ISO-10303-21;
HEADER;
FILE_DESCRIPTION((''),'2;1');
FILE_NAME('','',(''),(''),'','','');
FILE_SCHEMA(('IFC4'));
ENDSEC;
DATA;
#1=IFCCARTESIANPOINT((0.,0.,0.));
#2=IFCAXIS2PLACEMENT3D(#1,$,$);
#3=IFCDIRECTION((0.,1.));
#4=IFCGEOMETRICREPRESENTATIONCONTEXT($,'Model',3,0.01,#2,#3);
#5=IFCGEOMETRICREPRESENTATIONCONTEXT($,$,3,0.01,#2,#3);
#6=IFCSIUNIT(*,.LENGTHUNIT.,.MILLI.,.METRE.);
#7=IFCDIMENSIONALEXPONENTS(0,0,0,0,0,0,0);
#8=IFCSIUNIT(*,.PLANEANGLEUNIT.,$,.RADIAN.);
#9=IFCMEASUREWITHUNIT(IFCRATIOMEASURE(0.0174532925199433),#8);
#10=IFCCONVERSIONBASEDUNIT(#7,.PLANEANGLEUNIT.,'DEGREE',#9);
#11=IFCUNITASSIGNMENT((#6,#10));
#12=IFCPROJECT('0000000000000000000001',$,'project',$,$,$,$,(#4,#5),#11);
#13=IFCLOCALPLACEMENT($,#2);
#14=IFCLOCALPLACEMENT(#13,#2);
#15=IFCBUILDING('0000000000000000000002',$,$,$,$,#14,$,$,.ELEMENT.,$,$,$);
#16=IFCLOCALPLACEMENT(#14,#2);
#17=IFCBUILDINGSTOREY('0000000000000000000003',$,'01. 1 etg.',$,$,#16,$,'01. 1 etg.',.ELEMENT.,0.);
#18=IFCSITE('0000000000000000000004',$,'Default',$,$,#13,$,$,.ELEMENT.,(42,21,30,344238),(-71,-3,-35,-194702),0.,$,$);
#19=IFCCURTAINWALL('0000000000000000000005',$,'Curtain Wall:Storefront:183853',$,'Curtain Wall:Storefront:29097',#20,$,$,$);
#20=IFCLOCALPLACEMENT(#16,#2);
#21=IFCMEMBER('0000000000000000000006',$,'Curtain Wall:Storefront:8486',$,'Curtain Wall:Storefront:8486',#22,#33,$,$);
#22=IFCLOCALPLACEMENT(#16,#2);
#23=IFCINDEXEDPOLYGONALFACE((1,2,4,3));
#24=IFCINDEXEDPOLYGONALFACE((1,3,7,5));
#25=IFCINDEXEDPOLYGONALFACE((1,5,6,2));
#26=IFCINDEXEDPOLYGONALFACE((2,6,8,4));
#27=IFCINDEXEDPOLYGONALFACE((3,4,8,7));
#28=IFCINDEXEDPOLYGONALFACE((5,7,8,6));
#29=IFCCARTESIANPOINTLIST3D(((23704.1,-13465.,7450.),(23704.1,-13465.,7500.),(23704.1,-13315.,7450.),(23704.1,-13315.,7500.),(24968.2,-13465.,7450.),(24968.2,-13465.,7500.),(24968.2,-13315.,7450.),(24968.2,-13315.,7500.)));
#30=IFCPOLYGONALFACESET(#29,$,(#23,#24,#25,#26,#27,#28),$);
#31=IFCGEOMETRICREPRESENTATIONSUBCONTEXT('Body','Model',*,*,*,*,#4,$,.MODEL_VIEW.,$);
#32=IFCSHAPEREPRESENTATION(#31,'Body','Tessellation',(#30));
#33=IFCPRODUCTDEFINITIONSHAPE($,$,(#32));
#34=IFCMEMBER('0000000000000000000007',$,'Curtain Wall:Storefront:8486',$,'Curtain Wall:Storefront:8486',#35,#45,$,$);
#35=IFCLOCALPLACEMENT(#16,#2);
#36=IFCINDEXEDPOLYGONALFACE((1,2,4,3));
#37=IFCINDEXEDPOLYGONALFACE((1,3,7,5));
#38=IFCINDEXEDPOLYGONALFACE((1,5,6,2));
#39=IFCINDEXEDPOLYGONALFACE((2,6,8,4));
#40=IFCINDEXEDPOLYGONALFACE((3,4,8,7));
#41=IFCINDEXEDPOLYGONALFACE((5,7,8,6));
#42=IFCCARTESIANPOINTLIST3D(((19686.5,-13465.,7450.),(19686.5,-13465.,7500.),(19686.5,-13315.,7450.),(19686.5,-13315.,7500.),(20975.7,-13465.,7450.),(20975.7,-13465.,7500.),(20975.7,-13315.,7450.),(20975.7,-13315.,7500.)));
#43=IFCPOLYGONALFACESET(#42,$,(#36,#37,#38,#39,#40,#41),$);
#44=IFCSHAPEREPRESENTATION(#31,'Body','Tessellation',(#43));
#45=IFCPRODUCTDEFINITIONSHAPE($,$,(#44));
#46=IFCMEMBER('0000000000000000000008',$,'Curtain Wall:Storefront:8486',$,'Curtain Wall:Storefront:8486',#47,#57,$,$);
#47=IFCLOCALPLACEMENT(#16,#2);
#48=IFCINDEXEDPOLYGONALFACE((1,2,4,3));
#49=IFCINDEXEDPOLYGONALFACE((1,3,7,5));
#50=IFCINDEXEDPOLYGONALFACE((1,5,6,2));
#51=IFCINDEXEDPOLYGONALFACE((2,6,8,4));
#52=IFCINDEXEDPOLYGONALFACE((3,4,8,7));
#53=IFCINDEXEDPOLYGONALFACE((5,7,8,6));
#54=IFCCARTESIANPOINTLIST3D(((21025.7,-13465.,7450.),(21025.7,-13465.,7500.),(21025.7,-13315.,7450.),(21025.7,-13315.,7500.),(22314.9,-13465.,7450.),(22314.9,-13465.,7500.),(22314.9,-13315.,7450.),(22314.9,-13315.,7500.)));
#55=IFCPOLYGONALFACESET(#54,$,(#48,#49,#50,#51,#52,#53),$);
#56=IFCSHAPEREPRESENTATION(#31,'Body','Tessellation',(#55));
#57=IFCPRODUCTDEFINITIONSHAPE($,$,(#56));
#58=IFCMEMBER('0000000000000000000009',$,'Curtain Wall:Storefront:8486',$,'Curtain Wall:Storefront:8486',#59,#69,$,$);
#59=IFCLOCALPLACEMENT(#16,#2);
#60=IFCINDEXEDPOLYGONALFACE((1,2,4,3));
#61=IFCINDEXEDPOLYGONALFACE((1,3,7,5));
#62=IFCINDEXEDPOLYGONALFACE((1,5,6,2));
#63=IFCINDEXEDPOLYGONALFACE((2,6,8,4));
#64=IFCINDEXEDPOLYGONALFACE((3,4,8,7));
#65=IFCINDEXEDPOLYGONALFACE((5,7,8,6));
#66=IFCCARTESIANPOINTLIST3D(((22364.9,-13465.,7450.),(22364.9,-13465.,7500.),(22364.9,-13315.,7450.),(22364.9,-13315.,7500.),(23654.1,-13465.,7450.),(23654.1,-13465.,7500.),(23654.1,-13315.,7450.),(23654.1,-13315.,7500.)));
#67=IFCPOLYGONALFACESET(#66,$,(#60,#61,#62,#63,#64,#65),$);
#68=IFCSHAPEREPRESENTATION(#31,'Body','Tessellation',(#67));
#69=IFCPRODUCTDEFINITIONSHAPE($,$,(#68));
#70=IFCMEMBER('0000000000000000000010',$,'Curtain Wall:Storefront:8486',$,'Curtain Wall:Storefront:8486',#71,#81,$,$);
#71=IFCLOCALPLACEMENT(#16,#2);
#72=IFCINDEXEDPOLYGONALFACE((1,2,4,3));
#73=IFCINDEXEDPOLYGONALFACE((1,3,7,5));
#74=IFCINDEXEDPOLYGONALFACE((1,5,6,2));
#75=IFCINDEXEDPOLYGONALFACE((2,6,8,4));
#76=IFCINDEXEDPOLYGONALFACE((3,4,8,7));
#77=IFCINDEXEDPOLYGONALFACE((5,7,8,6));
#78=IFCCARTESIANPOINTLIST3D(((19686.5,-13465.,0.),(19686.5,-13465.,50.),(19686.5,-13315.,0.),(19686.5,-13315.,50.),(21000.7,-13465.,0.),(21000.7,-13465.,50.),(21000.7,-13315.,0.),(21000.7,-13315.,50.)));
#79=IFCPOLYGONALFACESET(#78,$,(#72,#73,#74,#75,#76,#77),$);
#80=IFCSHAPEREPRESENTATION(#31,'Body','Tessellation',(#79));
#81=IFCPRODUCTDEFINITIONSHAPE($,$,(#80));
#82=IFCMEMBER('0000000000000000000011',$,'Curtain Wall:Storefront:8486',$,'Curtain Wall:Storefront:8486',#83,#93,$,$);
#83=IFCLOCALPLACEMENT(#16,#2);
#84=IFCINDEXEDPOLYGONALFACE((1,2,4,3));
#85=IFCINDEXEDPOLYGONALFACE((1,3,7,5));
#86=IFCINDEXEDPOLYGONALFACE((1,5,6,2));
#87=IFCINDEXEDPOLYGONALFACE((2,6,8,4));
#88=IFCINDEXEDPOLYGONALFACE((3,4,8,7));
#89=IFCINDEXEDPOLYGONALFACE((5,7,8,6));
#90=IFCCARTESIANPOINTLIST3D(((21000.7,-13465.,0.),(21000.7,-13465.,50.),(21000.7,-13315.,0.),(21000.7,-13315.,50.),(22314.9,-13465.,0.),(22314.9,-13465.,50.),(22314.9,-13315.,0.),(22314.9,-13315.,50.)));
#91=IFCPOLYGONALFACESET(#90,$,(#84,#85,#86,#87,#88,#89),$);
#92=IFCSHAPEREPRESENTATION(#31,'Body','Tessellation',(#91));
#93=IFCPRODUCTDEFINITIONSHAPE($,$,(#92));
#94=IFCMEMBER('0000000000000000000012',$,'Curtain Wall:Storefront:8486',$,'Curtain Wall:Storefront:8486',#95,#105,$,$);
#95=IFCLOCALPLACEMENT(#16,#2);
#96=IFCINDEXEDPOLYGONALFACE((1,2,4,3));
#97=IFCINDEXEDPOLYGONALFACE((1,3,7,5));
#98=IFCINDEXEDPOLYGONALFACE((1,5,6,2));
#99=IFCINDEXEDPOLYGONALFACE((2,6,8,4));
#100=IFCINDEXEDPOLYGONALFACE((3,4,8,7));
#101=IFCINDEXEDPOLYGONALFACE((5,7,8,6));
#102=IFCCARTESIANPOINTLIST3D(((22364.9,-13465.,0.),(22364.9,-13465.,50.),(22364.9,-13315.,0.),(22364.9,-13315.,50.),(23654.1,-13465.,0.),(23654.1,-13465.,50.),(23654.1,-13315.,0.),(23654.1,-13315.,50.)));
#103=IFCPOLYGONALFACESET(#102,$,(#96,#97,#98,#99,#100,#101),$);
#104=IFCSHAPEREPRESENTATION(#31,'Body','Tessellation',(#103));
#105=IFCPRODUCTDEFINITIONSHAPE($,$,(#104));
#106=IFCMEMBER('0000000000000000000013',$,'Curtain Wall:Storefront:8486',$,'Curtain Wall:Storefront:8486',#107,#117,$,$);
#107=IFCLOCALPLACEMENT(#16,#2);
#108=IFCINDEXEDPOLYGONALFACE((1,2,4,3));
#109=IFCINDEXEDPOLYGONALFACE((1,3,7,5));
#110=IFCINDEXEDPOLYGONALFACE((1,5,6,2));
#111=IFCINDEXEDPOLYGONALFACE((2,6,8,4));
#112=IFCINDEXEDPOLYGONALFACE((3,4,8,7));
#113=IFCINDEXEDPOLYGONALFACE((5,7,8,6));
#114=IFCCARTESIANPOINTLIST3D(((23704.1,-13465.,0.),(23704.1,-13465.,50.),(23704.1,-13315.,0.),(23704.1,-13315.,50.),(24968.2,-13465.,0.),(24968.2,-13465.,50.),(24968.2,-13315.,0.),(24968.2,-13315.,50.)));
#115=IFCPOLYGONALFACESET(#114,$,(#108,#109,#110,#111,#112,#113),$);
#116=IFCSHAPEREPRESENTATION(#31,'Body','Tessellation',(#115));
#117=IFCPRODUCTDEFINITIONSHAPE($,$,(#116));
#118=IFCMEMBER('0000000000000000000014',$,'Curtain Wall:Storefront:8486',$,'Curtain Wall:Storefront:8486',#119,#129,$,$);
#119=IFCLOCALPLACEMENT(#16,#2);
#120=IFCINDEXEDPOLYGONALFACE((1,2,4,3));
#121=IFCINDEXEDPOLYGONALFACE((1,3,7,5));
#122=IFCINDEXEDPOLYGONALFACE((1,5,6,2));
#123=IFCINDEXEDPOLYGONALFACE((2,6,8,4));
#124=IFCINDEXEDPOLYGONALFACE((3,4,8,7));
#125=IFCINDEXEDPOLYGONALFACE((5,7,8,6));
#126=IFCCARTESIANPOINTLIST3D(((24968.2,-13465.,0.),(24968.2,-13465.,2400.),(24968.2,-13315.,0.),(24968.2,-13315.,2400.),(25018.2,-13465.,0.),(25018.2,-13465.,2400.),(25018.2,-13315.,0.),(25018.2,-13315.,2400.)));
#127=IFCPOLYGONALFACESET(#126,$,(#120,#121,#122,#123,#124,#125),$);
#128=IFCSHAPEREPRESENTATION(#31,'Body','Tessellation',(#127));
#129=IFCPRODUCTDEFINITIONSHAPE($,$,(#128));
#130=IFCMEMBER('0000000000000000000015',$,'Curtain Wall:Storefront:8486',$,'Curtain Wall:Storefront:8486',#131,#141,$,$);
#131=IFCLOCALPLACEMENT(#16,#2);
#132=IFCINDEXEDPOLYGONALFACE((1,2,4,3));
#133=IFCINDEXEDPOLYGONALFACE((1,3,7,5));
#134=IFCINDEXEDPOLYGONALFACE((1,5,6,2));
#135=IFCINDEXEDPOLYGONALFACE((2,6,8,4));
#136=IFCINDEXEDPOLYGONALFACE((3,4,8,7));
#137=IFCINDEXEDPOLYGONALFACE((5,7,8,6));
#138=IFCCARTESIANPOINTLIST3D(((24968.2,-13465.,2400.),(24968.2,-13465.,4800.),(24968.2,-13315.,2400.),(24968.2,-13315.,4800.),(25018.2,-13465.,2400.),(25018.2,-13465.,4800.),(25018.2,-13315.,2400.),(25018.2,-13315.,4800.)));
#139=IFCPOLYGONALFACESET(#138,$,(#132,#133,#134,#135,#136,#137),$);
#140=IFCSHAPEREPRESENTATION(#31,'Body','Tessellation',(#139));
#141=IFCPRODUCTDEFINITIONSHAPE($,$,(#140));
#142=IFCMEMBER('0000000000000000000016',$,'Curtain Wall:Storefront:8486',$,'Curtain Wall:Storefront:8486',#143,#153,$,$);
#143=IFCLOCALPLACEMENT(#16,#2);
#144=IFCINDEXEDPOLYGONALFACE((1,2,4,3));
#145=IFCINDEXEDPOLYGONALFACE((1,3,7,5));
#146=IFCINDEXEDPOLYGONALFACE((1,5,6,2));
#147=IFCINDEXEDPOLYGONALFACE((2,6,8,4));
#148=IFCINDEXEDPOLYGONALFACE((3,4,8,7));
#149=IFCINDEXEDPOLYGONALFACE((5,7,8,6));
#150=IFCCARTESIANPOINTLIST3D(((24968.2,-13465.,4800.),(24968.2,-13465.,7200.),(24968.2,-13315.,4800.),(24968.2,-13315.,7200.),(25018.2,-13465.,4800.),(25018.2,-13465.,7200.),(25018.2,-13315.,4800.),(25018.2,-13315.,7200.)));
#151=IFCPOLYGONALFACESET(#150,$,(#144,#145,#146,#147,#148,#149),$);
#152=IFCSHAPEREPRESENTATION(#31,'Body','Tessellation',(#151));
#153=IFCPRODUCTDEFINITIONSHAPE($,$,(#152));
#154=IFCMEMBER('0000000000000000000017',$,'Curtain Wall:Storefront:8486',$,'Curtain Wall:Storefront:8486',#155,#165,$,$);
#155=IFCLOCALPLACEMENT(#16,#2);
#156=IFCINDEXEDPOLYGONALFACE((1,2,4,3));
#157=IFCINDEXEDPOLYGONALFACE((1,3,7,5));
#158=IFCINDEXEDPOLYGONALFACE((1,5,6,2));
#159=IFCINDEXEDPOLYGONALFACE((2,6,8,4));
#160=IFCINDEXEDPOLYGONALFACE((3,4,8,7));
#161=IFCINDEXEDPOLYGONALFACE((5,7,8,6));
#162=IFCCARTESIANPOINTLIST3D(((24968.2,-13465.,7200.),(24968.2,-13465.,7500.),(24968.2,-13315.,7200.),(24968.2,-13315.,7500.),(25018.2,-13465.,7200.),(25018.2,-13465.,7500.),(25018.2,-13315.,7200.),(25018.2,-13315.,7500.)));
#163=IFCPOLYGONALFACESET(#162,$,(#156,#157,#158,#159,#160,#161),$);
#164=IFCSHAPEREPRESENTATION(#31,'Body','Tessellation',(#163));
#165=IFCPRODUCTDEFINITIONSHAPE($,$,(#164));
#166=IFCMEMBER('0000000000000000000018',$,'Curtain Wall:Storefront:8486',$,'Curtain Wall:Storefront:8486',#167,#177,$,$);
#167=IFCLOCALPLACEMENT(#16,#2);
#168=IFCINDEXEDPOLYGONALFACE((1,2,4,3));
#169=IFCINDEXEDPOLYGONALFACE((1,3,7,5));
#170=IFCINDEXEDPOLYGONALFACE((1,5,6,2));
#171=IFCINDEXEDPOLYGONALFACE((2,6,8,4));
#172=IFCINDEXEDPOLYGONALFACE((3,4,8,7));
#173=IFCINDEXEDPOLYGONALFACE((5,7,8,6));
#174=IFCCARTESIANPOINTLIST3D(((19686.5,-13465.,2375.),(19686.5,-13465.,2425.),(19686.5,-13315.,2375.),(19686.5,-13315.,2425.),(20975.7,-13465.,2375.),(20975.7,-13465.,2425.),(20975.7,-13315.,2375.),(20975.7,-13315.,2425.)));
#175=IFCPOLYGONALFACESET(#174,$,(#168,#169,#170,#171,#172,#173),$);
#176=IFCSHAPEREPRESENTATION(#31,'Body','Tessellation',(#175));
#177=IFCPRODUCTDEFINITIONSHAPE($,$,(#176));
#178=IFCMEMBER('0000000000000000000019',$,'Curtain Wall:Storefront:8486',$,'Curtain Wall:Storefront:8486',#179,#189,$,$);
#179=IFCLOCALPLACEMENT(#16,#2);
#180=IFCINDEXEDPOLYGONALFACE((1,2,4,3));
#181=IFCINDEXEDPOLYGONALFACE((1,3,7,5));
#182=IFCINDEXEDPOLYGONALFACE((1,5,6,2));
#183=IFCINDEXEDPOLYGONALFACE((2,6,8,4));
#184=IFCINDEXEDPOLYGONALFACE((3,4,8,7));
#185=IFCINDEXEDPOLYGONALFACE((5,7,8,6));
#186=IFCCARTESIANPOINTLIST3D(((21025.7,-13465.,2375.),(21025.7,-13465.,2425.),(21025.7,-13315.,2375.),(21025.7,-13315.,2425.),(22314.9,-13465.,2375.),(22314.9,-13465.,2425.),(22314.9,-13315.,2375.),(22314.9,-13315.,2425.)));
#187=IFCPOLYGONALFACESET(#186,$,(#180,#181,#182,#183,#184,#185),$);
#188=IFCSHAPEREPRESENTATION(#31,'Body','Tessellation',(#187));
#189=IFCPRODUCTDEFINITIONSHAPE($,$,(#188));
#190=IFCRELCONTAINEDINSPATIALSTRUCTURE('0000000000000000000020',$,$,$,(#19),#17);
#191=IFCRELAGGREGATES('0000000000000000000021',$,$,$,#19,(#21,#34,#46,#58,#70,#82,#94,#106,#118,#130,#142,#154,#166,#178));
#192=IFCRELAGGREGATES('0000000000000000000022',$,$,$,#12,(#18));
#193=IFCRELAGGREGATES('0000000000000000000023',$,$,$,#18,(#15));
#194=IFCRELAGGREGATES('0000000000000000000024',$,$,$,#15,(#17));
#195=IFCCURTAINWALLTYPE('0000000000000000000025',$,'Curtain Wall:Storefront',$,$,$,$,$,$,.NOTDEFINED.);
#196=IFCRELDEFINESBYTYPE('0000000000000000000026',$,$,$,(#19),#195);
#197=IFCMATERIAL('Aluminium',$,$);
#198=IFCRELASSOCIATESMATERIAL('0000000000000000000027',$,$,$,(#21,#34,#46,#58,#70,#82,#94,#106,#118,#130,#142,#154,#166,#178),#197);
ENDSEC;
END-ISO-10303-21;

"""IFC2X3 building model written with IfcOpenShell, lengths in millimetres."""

from ifc_helpers import new_model, entity, si_unit, converted_unit, direction, frame, frame_2d, origin, origin_2d_with_axis, place, context, subcontext, project, spatial, rectangle, extrude, material, type_object, element, aggregate, save


model = new_model("IFC2X3")

# Units and contexts
model_context = context("Model", 3, precision=0.01, world=origin(), true_north=direction((0.0, 1.0)))
context_of_model = context(None, 3, precision=0.01, world=origin(), true_north=direction((0.0, 1.0)))
body_context = subcontext(model_context, "Body", "Model", "MODEL_VIEW")
ifc_project = project(units=[si_unit("LENGTHUNIT", "METRE", prefix="MILLI"), converted_unit("PLANEANGLEUNIT", "DEGREE", entity("IfcRatioMeasure", 0.0174532925199433), si_unit("PLANEANGLEUNIT", "RADIAN"), dimensions=[0, 0, 0, 0, 0, 0, 0])], contexts=[model_context, context_of_model])

# Site, building, storey
site_placement = place(None, origin())
site = spatial("IfcSite", under=ifc_project, at=site_placement, Name="Default", CompositionType="ELEMENT", RefLatitude=(42, 21, 30, 344238), RefLongitude=(-71, -3, -35, -194702), RefElevation=0.0)
building_placement = place(site_placement, origin())
building = spatial("IfcBuilding", under=site, at=building_placement, CompositionType="ELEMENT")
storey_placement = place(building_placement, origin())
storey = spatial("IfcBuildingStorey", under=building, at=storey_placement, Name="01. 1 etg.", LongName="01. 1 etg.", CompositionType="ELEMENT", Elevation=0.0)

# Curtain wall, members
curtain_wall_type = type_object("IfcCurtainWallType", Name="Curtain Wall:Storefront", PredefinedType="NOTDEFINED")
curtain_wall_placement = place(storey_placement, origin())
curtain_wall = element("IfcCurtainWall", 1, at=curtain_wall_placement, inside=storey, type_object=curtain_wall_type, Name="Curtain Wall:Storefront:183853", ObjectType="Curtain Wall:Storefront:29097")
ifc_material_1 = material(Name="Aluminium")
member_1_placement = place(curtain_wall_placement, frame((23704.1, -13465.0, 7450.0)))
member_1 = element("IfcMember", 2, at=member_1_placement, material=ifc_material_1, Name="Curtain Wall:Storefront:8486", ObjectType="Curtain Wall:Storefront:8486", context=body_context, shape_type="SweptSolid", body=[
    extrude(rectangle(XDim=1264.2, YDim=150.0, at=origin_2d_with_axis()), frame((632.1, 75.0, 0.0), z_axis=(0.0, 0.0, 1.0), x_axis=(-1.0, 0.0, 0.0)), (0.0, 0.0, 1.0), 50.0),
])
member_2_placement = place(curtain_wall_placement, frame((19686.5, -13465.0, 7450.0)))
member_2 = element("IfcMember", 3, at=member_2_placement, material=ifc_material_1, Name="Curtain Wall:Storefront:8486", ObjectType="Curtain Wall:Storefront:8486", context=body_context, shape_type="SweptSolid", body=[
    extrude(rectangle(XDim=1289.2, YDim=150.0, at=origin_2d_with_axis()), frame((644.6, 75.0, 0.0), z_axis=(0.0, 0.0, 1.0), x_axis=(-1.0, 0.0, 0.0)), (0.0, 0.0, 1.0), 50.0),
])
member_3_placement = place(curtain_wall_placement, frame((21025.7, -13465.0, 7450.0)))
member_3 = element("IfcMember", 4, at=member_3_placement, material=ifc_material_1, Name="Curtain Wall:Storefront:8486", ObjectType="Curtain Wall:Storefront:8486", context=body_context, shape_type="SweptSolid", body=[
    extrude(rectangle(XDim=1289.2, YDim=150.0, at=origin_2d_with_axis()), frame((644.6, 75.0, 0.0), z_axis=(0.0, 0.0, 1.0), x_axis=(-1.0, 0.0, 0.0)), (0.0, 0.0, 1.0), 50.0),
])
member_4_placement = place(curtain_wall_placement, frame((22364.9, -13465.0, 7450.0)))
member_4 = element("IfcMember", 5, at=member_4_placement, material=ifc_material_1, Name="Curtain Wall:Storefront:8486", ObjectType="Curtain Wall:Storefront:8486", context=body_context, shape_type="SweptSolid", body=[
    extrude(rectangle(XDim=1289.2, YDim=150.0, at=origin_2d_with_axis()), frame((644.6, 75.0, 0.0), z_axis=(0.0, 0.0, 1.0), x_axis=(-1.0, 0.0, 0.0)), (0.0, 0.0, 1.0), 50.0),
])
member_5_placement = place(curtain_wall_placement, frame((19686.5, -13465.0, 0.0)))
member_5 = element("IfcMember", 6, at=member_5_placement, material=ifc_material_1, Name="Curtain Wall:Storefront:8486", ObjectType="Curtain Wall:Storefront:8486", context=body_context, shape_type="SweptSolid", body=[
    extrude(rectangle(XDim=1314.2, YDim=150.0, at=origin_2d_with_axis()), frame((657.1, 75.0, 0.0)), (0.0, 0.0, 1.0), 50.0),
])
member_6_placement = place(curtain_wall_placement, frame((21000.7, -13465.0, 0.0)))
member_6 = element("IfcMember", 7, at=member_6_placement, material=ifc_material_1, Name="Curtain Wall:Storefront:8486", ObjectType="Curtain Wall:Storefront:8486", context=body_context, shape_type="SweptSolid", body=[
    extrude(rectangle(XDim=1314.2, YDim=150.0, at=frame_2d((0.0, 0.0), x_axis=(1.0, 0.0))), frame((657.1, 75.0, 0.0)), (0.0, 0.0, 1.0), 50.0),
])
member_7_placement = place(curtain_wall_placement, frame((22364.9, -13465.0, 0.0)))
member_7 = element("IfcMember", 8, at=member_7_placement, material=ifc_material_1, Name="Curtain Wall:Storefront:8486", ObjectType="Curtain Wall:Storefront:8486", context=body_context, shape_type="SweptSolid", body=[
    extrude(rectangle(XDim=1289.2, YDim=150.0, at=origin_2d_with_axis()), frame((644.6, 75.0, 0.0)), (0.0, 0.0, 1.0), 50.0),
])
member_8_placement = place(curtain_wall_placement, frame((23704.1, -13465.0, 0.0)))
member_8 = element("IfcMember", 9, at=member_8_placement, material=ifc_material_1, Name="Curtain Wall:Storefront:8486", ObjectType="Curtain Wall:Storefront:8486", context=body_context, shape_type="SweptSolid", body=[
    extrude(rectangle(XDim=1264.2, YDim=150.0, at=frame_2d((0.0, 0.0), x_axis=(1.0, 0.0))), frame((632.1, 75.0, 0.0)), (0.0, 0.0, 1.0), 50.0),
])
member_9_placement = place(curtain_wall_placement, frame((24968.2, -13465.0, 0.0)))
member_9 = element("IfcMember", 10, at=member_9_placement, material=ifc_material_1, Name="Curtain Wall:Storefront:8486", ObjectType="Curtain Wall:Storefront:8486", context=body_context, shape_type="SweptSolid", body=[
    extrude(rectangle(XDim=150.0, YDim=50.0, at=frame_2d((0.0, 0.0), x_axis=(1.0, 0.0))), frame((25.0, 75.0, 0.0), z_axis=(0.0, 0.0, 1.0), x_axis=(0.0, 1.0, 0.0)), (0.0, 0.0, 1.0), 2400.0),
])
member_10_placement = place(curtain_wall_placement, frame((24968.2, -13465.0, 2400.0)))
member_10 = element("IfcMember", 11, at=member_10_placement, material=ifc_material_1, Name="Curtain Wall:Storefront:8486", ObjectType="Curtain Wall:Storefront:8486", context=body_context, shape_type="SweptSolid", body=[
    extrude(rectangle(XDim=150.0, YDim=50.0, at=frame_2d((0.0, 0.0), x_axis=(1.0, 0.0))), frame((25.0, 75.0, 0.0), z_axis=(0.0, 0.0, 1.0), x_axis=(0.0, 1.0, 0.0)), (0.0, 0.0, 1.0), 2400.0),
])
member_11_placement = place(curtain_wall_placement, frame((24968.2, -13465.0, 4800.0)))
member_11 = element("IfcMember", 12, at=member_11_placement, material=ifc_material_1, Name="Curtain Wall:Storefront:8486", ObjectType="Curtain Wall:Storefront:8486", context=body_context, shape_type="SweptSolid", body=[
    extrude(rectangle(XDim=150.0, YDim=50.0, at=frame_2d((0.0, 0.0), x_axis=(1.0, 0.0))), frame((25.0, 75.0, 0.0), z_axis=(0.0, 0.0, 1.0), x_axis=(0.0, 1.0, 0.0)), (0.0, 0.0, 1.0), 2400.0),
])
member_12_placement = place(curtain_wall_placement, frame((24968.2, -13465.0, 7200.0)))
member_12 = element("IfcMember", 13, at=member_12_placement, material=ifc_material_1, Name="Curtain Wall:Storefront:8486", ObjectType="Curtain Wall:Storefront:8486", context=body_context, shape_type="SweptSolid", body=[
    extrude(rectangle(XDim=150.0, YDim=50.0, at=frame_2d((0.0, 0.0), x_axis=(1.0, 0.0))), frame((25.0, 75.0, 0.0), z_axis=(0.0, 0.0, 1.0), x_axis=(0.0, 1.0, 0.0)), (0.0, 0.0, 1.0), 300.0),
])
member_13_placement = place(curtain_wall_placement, frame((19686.5, -13465.0, 2375.0)))
member_13 = element("IfcMember", 14, at=member_13_placement, material=ifc_material_1, Name="Curtain Wall:Storefront:8486", ObjectType="Curtain Wall:Storefront:8486", context=body_context, shape_type="SweptSolid", body=[
    extrude(rectangle(XDim=1289.2, YDim=150.0, at=frame_2d((0.0, 0.0), x_axis=(1.0, 0.0))), frame((644.6, 75.0, 0.0), z_axis=(0.0, 0.0, 1.0), x_axis=(-1.0, 0.0, 0.0)), (0.0, 0.0, 1.0), 50.0),
])
member_14_placement = place(curtain_wall_placement, frame((21025.7, -13465.0, 2375.0)))
member_14 = element("IfcMember", 15, at=member_14_placement, material=ifc_material_1, Name="Curtain Wall:Storefront:8486", ObjectType="Curtain Wall:Storefront:8486", context=body_context, shape_type="SweptSolid", body=[
    extrude(rectangle(XDim=1289.2, YDim=150.0, at=frame_2d((0.0, 0.0), x_axis=(1.0, 0.0))), frame((644.6, 75.0, 0.0), z_axis=(0.0, 0.0, 1.0), x_axis=(-1.0, 0.0, 0.0)), (0.0, 0.0, 1.0), 50.0),
])
aggregate(curtain_wall, [member_1, member_2, member_3, member_4, member_5, member_6, member_7, member_8, member_9, member_10, member_11, member_12, member_13, member_14])

save(model, "model.ifc")
